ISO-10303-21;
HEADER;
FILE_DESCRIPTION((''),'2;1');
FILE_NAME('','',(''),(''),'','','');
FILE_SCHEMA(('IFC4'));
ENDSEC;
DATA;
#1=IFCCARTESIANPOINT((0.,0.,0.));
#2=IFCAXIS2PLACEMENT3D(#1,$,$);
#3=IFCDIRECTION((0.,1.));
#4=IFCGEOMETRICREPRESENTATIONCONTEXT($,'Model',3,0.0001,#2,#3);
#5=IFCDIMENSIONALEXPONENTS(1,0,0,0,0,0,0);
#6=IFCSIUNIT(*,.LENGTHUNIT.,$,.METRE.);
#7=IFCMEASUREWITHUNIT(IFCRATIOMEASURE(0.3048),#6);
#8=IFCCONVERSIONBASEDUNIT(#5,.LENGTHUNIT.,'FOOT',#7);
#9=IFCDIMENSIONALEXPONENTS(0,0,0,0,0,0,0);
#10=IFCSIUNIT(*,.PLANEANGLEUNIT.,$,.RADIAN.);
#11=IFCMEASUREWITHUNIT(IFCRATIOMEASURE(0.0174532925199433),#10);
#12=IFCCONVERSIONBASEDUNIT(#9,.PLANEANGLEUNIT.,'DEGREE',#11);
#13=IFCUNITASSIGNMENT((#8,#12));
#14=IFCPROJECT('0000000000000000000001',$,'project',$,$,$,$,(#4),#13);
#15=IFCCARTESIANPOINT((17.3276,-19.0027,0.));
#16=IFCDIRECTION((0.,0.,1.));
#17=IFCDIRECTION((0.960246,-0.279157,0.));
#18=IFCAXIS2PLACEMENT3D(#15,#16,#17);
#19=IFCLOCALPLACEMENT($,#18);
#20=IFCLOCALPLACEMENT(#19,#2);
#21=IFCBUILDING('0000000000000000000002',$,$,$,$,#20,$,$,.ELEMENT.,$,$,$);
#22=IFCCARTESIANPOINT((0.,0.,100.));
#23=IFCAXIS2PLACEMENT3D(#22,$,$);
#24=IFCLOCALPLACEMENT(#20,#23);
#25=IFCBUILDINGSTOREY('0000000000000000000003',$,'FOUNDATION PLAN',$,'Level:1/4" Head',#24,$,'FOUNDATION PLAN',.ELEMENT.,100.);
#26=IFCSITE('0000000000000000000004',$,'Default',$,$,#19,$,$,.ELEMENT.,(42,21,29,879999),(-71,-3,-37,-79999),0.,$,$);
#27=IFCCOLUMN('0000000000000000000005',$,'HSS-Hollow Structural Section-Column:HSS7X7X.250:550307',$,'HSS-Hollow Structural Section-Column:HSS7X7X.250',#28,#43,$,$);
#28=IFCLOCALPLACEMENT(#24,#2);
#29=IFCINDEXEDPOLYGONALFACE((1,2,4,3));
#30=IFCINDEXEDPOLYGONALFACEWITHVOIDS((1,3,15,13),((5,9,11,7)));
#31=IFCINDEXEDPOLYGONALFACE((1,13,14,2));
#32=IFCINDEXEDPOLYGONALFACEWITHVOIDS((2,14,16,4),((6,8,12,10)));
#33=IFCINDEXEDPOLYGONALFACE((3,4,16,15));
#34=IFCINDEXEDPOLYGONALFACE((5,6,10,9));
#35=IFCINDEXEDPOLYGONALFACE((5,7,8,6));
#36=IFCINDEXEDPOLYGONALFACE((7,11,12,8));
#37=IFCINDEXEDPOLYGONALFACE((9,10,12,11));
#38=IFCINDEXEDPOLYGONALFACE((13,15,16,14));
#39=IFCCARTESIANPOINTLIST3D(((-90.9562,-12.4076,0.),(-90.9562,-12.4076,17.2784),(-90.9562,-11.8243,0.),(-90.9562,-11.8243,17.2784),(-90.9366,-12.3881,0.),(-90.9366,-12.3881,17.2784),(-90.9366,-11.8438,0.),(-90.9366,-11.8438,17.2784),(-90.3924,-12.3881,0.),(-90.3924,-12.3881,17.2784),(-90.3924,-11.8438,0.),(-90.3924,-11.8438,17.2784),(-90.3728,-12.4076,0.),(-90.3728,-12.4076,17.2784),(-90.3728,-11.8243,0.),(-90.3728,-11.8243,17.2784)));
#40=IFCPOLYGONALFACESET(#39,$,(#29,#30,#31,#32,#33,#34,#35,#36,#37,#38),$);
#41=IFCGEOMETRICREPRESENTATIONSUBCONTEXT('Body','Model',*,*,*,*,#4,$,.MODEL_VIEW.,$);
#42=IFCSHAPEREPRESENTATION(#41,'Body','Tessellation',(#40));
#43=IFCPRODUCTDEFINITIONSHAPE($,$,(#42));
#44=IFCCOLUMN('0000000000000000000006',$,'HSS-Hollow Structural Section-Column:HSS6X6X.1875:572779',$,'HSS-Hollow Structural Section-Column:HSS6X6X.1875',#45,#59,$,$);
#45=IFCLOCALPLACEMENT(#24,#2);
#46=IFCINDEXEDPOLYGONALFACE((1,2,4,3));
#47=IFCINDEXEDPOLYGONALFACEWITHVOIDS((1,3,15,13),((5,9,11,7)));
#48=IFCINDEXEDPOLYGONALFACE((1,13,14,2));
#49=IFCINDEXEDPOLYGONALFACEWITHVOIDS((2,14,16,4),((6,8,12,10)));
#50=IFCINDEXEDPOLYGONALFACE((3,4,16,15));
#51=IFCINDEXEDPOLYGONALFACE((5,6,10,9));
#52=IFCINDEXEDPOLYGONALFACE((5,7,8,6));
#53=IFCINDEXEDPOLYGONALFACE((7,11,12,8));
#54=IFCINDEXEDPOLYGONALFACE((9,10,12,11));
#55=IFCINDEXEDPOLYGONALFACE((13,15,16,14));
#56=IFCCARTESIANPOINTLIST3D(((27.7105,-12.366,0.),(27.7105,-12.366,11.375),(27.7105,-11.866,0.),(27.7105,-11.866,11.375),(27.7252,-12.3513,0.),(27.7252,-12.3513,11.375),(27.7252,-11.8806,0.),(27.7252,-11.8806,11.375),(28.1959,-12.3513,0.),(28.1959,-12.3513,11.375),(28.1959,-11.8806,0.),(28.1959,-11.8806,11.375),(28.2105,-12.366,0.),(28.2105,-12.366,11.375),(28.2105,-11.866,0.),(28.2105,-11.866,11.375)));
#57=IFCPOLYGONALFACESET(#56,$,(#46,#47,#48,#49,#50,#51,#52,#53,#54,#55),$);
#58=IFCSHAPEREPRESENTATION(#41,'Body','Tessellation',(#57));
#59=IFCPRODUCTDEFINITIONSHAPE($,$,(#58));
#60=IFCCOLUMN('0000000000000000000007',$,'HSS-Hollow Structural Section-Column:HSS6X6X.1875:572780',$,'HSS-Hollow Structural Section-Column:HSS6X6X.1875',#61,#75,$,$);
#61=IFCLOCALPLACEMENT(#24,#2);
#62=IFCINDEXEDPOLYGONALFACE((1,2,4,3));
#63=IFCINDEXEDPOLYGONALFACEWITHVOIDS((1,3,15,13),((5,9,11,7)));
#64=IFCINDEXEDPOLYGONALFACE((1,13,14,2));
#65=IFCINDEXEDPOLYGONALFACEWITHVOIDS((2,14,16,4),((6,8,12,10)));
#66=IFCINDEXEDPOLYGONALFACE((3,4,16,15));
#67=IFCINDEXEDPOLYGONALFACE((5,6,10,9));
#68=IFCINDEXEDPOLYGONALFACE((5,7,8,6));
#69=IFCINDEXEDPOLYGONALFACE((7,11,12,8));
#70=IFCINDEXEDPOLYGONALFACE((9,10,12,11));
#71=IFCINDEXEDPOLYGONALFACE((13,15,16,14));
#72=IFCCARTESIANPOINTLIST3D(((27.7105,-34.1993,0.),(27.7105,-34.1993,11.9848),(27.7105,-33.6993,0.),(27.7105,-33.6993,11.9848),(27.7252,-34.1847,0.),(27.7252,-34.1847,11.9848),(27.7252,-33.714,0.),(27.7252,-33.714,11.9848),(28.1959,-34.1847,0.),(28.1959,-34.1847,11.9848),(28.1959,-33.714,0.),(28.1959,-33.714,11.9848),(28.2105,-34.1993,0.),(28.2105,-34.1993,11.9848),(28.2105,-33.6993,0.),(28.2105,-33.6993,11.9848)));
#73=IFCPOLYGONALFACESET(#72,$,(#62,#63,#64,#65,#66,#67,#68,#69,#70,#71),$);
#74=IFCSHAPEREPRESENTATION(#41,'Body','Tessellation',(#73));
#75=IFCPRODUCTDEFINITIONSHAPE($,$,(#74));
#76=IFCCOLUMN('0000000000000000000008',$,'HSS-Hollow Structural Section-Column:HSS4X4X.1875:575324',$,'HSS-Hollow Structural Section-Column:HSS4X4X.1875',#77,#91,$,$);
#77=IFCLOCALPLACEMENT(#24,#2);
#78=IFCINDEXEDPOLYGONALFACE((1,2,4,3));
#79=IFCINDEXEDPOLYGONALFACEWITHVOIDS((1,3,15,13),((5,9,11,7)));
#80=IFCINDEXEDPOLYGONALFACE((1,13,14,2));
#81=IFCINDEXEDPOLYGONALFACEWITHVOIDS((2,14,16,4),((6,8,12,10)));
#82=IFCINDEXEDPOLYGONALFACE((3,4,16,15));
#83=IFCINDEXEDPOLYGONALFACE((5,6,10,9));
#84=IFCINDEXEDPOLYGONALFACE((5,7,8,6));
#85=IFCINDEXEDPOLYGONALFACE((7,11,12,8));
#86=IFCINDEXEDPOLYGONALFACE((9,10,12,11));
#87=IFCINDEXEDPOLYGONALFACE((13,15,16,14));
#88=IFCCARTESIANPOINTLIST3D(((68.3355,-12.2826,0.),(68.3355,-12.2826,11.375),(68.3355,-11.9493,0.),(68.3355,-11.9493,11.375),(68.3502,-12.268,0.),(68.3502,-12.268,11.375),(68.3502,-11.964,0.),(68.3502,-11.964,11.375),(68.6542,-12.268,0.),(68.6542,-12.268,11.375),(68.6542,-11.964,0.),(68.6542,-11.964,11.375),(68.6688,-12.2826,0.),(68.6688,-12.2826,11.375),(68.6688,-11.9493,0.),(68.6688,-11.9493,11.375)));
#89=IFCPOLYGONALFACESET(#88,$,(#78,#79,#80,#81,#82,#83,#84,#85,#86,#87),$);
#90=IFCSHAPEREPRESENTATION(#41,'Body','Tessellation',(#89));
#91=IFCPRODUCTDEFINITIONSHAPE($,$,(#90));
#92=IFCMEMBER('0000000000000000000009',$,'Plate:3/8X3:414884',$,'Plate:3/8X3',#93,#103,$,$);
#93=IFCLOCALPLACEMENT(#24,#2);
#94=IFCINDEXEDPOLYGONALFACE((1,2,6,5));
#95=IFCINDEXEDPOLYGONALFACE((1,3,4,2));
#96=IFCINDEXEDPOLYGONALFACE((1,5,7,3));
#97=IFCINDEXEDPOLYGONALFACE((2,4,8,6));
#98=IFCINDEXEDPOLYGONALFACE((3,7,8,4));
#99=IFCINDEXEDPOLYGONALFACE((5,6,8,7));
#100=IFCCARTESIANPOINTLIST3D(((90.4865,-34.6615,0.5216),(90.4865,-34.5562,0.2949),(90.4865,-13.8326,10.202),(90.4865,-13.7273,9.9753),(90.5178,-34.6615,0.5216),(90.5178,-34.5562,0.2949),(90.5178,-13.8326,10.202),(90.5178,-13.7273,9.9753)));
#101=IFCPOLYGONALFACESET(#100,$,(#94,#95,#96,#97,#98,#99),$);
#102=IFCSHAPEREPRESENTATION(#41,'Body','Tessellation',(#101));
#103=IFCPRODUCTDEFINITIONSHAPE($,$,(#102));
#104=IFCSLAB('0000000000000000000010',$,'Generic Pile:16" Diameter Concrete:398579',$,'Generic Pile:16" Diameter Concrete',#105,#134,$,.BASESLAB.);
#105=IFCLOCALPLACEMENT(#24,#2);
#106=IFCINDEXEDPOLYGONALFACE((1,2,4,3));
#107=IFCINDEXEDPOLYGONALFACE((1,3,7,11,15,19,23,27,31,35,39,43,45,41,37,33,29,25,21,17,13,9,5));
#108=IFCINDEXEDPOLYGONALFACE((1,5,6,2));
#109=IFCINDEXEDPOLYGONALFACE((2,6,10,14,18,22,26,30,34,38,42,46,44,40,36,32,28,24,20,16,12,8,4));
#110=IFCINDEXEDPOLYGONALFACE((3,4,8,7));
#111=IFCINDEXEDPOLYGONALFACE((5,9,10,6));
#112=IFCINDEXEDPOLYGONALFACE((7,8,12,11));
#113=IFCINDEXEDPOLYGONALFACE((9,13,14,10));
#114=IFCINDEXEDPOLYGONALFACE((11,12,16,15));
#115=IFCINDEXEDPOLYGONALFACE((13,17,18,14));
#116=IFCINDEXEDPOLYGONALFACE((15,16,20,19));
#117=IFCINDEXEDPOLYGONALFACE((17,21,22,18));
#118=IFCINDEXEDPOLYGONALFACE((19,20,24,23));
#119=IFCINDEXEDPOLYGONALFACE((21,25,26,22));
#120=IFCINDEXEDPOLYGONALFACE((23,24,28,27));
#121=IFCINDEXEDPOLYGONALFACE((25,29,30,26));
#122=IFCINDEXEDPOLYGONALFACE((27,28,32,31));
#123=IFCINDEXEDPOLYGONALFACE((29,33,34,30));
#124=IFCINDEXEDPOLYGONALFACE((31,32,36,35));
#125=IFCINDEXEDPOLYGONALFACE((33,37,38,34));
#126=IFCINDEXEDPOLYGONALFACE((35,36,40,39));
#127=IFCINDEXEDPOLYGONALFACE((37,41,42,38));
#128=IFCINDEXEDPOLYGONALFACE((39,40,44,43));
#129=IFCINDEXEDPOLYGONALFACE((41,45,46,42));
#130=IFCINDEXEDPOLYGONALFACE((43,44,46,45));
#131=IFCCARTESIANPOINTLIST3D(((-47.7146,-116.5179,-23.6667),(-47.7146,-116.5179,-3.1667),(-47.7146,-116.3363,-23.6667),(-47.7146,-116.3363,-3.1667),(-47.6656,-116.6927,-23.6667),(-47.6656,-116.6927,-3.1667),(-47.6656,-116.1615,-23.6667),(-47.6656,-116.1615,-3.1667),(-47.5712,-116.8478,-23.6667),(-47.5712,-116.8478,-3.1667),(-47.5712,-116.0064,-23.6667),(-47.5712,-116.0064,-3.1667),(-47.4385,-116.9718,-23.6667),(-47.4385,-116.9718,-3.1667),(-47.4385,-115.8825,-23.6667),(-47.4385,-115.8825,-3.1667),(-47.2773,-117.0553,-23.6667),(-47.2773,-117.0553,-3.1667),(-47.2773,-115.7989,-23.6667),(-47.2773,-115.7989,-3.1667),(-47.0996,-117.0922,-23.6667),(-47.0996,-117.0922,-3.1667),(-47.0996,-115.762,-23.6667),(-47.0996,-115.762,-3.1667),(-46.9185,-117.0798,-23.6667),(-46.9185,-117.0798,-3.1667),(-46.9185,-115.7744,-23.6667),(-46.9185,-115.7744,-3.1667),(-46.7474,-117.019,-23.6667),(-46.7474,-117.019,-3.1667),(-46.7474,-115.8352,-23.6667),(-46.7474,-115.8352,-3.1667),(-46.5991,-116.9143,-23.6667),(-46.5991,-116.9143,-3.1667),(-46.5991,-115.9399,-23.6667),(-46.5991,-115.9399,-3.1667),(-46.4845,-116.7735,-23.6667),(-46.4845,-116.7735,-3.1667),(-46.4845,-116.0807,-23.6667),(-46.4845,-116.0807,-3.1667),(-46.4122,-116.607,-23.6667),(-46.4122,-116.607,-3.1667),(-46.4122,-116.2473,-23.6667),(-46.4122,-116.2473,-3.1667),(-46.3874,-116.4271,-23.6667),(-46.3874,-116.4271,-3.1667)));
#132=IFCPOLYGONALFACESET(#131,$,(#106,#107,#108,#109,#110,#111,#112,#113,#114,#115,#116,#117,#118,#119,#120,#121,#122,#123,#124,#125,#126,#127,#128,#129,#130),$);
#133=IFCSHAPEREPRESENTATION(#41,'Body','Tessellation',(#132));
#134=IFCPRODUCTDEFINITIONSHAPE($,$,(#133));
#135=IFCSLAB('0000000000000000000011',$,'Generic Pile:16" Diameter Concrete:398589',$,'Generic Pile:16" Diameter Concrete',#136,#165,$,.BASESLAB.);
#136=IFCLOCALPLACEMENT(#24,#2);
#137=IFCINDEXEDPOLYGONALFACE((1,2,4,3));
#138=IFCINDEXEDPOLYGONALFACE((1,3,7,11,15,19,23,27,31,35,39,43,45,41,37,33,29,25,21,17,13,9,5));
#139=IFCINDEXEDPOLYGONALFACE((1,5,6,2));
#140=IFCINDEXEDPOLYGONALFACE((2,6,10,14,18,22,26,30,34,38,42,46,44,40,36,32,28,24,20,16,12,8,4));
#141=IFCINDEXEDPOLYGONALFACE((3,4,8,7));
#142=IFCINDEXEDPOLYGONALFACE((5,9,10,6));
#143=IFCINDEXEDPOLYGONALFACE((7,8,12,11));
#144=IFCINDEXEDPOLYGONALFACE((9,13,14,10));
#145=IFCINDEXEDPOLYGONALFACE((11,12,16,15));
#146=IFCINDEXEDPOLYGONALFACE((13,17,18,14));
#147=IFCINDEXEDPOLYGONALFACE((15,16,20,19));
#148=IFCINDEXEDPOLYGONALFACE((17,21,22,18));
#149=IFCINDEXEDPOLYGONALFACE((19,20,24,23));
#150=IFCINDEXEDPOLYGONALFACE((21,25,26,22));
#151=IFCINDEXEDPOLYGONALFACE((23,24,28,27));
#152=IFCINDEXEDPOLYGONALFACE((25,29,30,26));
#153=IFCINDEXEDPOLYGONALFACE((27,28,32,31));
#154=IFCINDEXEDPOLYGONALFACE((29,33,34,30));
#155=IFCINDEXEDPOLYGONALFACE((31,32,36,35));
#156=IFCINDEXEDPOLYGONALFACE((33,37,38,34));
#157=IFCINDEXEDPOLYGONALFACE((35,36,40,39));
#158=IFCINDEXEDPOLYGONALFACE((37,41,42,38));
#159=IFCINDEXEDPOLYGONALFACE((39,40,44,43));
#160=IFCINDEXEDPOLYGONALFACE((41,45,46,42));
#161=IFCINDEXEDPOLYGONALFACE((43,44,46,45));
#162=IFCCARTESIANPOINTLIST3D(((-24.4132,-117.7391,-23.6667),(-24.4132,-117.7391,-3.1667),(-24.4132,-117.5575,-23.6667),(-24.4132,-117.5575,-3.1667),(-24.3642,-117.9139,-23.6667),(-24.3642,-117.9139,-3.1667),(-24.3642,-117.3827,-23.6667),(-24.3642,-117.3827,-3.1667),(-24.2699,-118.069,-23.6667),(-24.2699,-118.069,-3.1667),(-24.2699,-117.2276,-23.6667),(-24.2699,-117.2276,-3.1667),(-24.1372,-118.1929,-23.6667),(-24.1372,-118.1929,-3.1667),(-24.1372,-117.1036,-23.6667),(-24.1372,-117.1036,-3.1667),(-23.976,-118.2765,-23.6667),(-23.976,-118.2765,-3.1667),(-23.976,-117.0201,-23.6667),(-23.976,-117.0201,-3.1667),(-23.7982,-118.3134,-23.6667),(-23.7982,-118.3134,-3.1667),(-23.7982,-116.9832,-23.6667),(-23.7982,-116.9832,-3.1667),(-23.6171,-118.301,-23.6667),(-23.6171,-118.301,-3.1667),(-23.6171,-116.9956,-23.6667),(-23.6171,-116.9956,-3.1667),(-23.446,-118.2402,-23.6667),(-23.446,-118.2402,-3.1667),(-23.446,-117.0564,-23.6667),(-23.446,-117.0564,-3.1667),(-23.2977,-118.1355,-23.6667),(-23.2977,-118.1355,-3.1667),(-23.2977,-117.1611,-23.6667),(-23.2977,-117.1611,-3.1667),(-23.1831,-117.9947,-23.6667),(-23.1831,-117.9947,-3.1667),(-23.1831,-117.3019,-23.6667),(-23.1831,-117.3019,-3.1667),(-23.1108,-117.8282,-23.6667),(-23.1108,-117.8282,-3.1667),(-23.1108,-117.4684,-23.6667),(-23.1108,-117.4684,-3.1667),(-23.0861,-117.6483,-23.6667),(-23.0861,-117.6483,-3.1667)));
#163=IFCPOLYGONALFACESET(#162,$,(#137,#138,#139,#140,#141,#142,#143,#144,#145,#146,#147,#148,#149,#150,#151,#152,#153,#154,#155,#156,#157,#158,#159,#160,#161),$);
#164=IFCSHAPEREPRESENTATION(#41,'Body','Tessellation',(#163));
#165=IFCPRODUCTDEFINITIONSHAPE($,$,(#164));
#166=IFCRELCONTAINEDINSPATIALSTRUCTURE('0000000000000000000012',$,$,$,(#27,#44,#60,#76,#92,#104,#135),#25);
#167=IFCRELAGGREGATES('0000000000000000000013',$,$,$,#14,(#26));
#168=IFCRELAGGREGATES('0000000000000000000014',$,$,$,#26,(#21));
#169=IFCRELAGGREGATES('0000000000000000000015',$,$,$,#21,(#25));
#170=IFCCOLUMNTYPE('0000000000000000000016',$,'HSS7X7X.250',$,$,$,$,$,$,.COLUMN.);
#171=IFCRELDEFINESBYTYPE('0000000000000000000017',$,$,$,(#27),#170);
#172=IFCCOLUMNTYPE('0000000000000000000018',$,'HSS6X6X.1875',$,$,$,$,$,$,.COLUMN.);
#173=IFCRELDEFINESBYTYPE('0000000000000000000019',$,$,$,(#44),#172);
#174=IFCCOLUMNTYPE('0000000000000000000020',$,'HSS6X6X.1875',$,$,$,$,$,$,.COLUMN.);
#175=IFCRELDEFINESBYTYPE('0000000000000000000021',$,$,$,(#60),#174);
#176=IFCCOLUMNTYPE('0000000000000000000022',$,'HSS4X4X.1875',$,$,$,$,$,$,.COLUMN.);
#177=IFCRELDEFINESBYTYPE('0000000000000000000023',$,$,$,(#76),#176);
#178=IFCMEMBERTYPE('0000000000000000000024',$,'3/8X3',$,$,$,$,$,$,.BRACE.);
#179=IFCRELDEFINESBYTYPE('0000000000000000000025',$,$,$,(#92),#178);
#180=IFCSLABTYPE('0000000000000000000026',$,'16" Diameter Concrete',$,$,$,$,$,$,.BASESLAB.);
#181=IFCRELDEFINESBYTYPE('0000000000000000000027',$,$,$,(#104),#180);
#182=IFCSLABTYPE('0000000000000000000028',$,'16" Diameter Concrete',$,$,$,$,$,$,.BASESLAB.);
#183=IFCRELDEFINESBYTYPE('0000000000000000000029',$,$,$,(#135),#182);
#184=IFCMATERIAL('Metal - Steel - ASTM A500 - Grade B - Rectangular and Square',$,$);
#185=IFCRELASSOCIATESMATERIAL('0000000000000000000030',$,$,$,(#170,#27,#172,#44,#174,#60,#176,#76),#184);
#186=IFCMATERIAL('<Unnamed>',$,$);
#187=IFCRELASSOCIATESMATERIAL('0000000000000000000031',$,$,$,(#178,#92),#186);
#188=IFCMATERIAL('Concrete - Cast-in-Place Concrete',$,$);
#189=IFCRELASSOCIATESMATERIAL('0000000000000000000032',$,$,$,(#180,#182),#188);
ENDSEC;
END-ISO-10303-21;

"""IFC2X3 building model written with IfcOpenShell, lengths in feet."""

from ifc_helpers import new_model, entity, si_unit, converted_unit, direction, frame, frame_2d, origin, origin_2d_with_axis, place, context, subcontext, project, spatial, rectangle, circle, extrude, boolean, source, transform, mapped, material, type_object, type_shapes, element, save


model = new_model("IFC2X3")

# Units and contexts
model_context = context("Model", 3, precision=0.0001, world=origin(), true_north=direction((0.0, 1.0)))
body_context = subcontext(model_context, "Body", "Model", "MODEL_VIEW")
ifc_project = project(units=[converted_unit("LENGTHUNIT", "FOOT", entity("IfcRatioMeasure", 0.3048), si_unit("LENGTHUNIT", "METRE"), dimensions=[1, 0, 0, 0, 0, 0, 0]), converted_unit("PLANEANGLEUNIT", "DEGREE", entity("IfcRatioMeasure", 0.0174532925199433), si_unit("PLANEANGLEUNIT", "RADIAN"), dimensions=[0, 0, 0, 0, 0, 0, 0])], contexts=[model_context])

# Site, building, storey
site_placement = place(None, frame((17.3276, -19.0027, 0.0), z_axis=(0.0, 0.0, 1.0), x_axis=(0.960246, -0.279157, 0.0)))
site = spatial("IfcSite", under=ifc_project, at=site_placement, Name="Default", CompositionType="ELEMENT", RefLatitude=(42, 21, 29, 879999), RefLongitude=(-71, -3, -37, -79999), RefElevation=0.0)
building_placement = place(site_placement, origin())
building = spatial("IfcBuilding", under=site, at=building_placement, CompositionType="ELEMENT")
storey_placement = place(building_placement, frame((0.0, 0.0, 100.0)))
storey = spatial("IfcBuildingStorey", under=building, at=storey_placement, Name="FOUNDATION PLAN", ObjectType="Level:1/4\" Head", LongName="FOUNDATION PLAN", CompositionType="ELEMENT", Elevation=100.0)

# Columns
ifc_material_1 = material(Name="Metal - Steel - ASTM A500 - Grade B - Rectangular and Square")
column_type_1 = type_object("IfcColumnType", Name="HSS7X7X.250", PredefinedType="COLUMN", material=ifc_material_1)
shared_shape_1 = source(origin(), body_context, "Body", "SweptSolid", [
    boolean("DIFFERENCE", extrude(rectangle(XDim=0.5833, YDim=0.5833, at=origin_2d_with_axis()), frame((-90.6645, -12.116, 100.0), z_axis=(0.0, 0.0, 1.0), x_axis=(0.0, -1.0, 0.0)), (0.0, 0.0, 1.0), 17.2784), extrude(rectangle(XDim=0.5443, YDim=0.5443, at=frame_2d((0.0, 0.0), x_axis=(1.0, 0.0))), frame((-90.6645, -12.116, 117.2784), z_axis=(0.0, 0.0, -1.0), x_axis=(0.0, -1.0, 0.0)), (0.0, 0.0, 1.0), 17.2784)),
])
type_shapes(column_type_1, [shared_shape_1])
column_1_placement = place(storey_placement, frame((0.0, 0.0, -100.0)))
element("IfcColumn", 1, at=column_1_placement, inside=storey, type_object=column_type_1, material=ifc_material_1, Name="HSS-Hollow Structural Section-Column:HSS7X7X.250:550307", ObjectType="HSS-Hollow Structural Section-Column:HSS7X7X.250", context=body_context, shape_type="MappedRepresentation", body=[
    mapped(shared_shape_1, transform((0.0, 0.0, 0.0), scale=1.0)),
])
column_type_2 = type_object("IfcColumnType", Name="HSS6X6X.1875", PredefinedType="COLUMN", material=ifc_material_1)
shared_shape_2 = source(origin(), body_context, "Body", "SweptSolid", [
    boolean("DIFFERENCE", extrude(rectangle(XDim=0.5, YDim=0.5, at=origin_2d_with_axis()), frame((27.9605, -12.116, 100.0), z_axis=(0.0, 0.0, 1.0), x_axis=(0.0, -1.0, 0.0)), (0.0, 0.0, 1.0), 11.375), extrude(rectangle(XDim=0.4707, YDim=0.4707, at=origin_2d_with_axis()), frame((27.9605, -12.116, 111.375), z_axis=(0.0, 0.0, -1.0), x_axis=(0.0, -1.0, 0.0)), (0.0, 0.0, 1.0), 11.375)),
])
type_shapes(column_type_2, [shared_shape_2])
column_2_placement = place(storey_placement, frame((0.0, 0.0, -100.0)))
element("IfcColumn", 2, at=column_2_placement, inside=storey, type_object=column_type_2, material=ifc_material_1, Name="HSS-Hollow Structural Section-Column:HSS6X6X.1875:572779", ObjectType="HSS-Hollow Structural Section-Column:HSS6X6X.1875", context=body_context, shape_type="MappedRepresentation", body=[
    mapped(shared_shape_2, transform((0.0, 0.0, 0.0), scale=1.0)),
])
column_type_3 = type_object("IfcColumnType", Name="HSS6X6X.1875", PredefinedType="COLUMN", material=ifc_material_1)
shared_shape_3 = source(origin(), body_context, "Body", "SweptSolid", [
    boolean("DIFFERENCE", extrude(rectangle(XDim=0.5, YDim=0.5, at=origin_2d_with_axis()), frame((27.9605, -33.9493, 100.0), z_axis=(0.0, 0.0, 1.0), x_axis=(0.0, -1.0, 0.0)), (0.0, 0.0, 1.0), 11.9848), extrude(rectangle(XDim=0.4707, YDim=0.4707, at=origin_2d_with_axis()), frame((27.9605, -33.9493, 111.9848), z_axis=(0.0, 0.0, -1.0), x_axis=(0.0, -1.0, 0.0)), (0.0, 0.0, 1.0), 11.9848)),
])
type_shapes(column_type_3, [shared_shape_3])
column_3_placement = place(storey_placement, frame((0.0, 0.0, -100.0)))
element("IfcColumn", 3, at=column_3_placement, inside=storey, type_object=column_type_3, material=ifc_material_1, Name="HSS-Hollow Structural Section-Column:HSS6X6X.1875:572780", ObjectType="HSS-Hollow Structural Section-Column:HSS6X6X.1875", context=body_context, shape_type="MappedRepresentation", body=[
    mapped(shared_shape_3, transform((0.0, 0.0, 0.0), scale=1.0)),
])
column_type_4 = type_object("IfcColumnType", Name="HSS4X4X.1875", PredefinedType="COLUMN", material=ifc_material_1)
shared_shape_4 = source(origin(), body_context, "Body", "SweptSolid", [
    boolean("DIFFERENCE", extrude(rectangle(XDim=0.3333, YDim=0.3333, at=origin_2d_with_axis()), frame((68.5022, -12.116, 100.0), z_axis=(0.0, 0.0, 1.0), x_axis=(0.0, -1.0, 0.0)), (0.0, 0.0, 1.0), 11.375), extrude(rectangle(XDim=0.304, YDim=0.304, at=frame_2d((0.0, 0.0), x_axis=(1.0, 0.0))), frame((68.5022, -12.116, 111.375), z_axis=(0.0, 0.0, -1.0), x_axis=(0.0, -1.0, 0.0)), (0.0, 0.0, 1.0), 11.375)),
])
type_shapes(column_type_4, [shared_shape_4])
column_4_placement = place(storey_placement, frame((0.0, 0.0, -100.0)))
element("IfcColumn", 4, at=column_4_placement, inside=storey, type_object=column_type_4, material=ifc_material_1, Name="HSS-Hollow Structural Section-Column:HSS4X4X.1875:575324", ObjectType="HSS-Hollow Structural Section-Column:HSS4X4X.1875", context=body_context, shape_type="MappedRepresentation", body=[
    mapped(shared_shape_4, transform((0.0, 0.0, 0.0), scale=1.0)),
])

# Member
ifc_material_2 = material(Name="<Unnamed>")
member_type = type_object("IfcMemberType", Name="3/8X3", PredefinedType="BRACE", material=ifc_material_2)
shared_shape_5 = source(origin(), body_context, "Body", "SweptSolid", [
    extrude(rectangle(XDim=0.25, YDim=0.0313, at=frame_2d((0.0, 0.0), x_axis=(1.0, 0.0))), frame((90.5022, -34.6088, 100.4082), z_axis=(0.0, 0.906845, 0.421463), x_axis=(0.0, -0.421463, 0.906845)), (0.0, 0.0, 1.0), 22.9685),
])
type_shapes(member_type, [shared_shape_5])
member_placement = place(storey_placement, frame((0.0, 0.0, -100.0)))
element("IfcMember", 5, at=member_placement, inside=storey, type_object=member_type, material=ifc_material_2, Name="Plate:3/8X3:414884", ObjectType="Plate:3/8X3", context=body_context, shape_type="MappedRepresentation", body=[
    mapped(shared_shape_5, transform((0.0, 0.0, 0.0), scale=1.0)),
])

# Slabs
ifc_material_3 = material(Name="Concrete - Cast-in-Place Concrete")
slab_type_1 = type_object("IfcSlabType", Name="16\" Diameter Concrete", PredefinedType="BASESLAB", material=ifc_material_3)
slab_1_placement = place(storey_placement, origin())
element("IfcSlab", 6, at=slab_1_placement, inside=storey, type_object=slab_type_1, Name="Generic Pile:16\" Diameter Concrete:398579", ObjectType="Generic Pile:16\" Diameter Concrete", PredefinedType="BASESLAB", context=body_context, shape_type="SweptSolid", body=[
    extrude(circle(Radius=0.6667, at=origin_2d_with_axis()), frame((-47.0541, -116.4271, -23.6667)), (0.0, 0.0, 1.0), 20.5),
])
slab_type_2 = type_object("IfcSlabType", Name="16\" Diameter Concrete", PredefinedType="BASESLAB", material=ifc_material_3)
slab_2_placement = place(storey_placement, origin())
element("IfcSlab", 7, at=slab_2_placement, inside=storey, type_object=slab_type_2, Name="Generic Pile:16\" Diameter Concrete:398589", ObjectType="Generic Pile:16\" Diameter Concrete", PredefinedType="BASESLAB", context=body_context, shape_type="SweptSolid", body=[
    extrude(circle(Radius=0.6667, at=origin_2d_with_axis()), frame((-23.7527, -117.6483, -23.6667)), (0.0, 0.0, 1.0), 20.5),
])

save(model, "model.ifc")
